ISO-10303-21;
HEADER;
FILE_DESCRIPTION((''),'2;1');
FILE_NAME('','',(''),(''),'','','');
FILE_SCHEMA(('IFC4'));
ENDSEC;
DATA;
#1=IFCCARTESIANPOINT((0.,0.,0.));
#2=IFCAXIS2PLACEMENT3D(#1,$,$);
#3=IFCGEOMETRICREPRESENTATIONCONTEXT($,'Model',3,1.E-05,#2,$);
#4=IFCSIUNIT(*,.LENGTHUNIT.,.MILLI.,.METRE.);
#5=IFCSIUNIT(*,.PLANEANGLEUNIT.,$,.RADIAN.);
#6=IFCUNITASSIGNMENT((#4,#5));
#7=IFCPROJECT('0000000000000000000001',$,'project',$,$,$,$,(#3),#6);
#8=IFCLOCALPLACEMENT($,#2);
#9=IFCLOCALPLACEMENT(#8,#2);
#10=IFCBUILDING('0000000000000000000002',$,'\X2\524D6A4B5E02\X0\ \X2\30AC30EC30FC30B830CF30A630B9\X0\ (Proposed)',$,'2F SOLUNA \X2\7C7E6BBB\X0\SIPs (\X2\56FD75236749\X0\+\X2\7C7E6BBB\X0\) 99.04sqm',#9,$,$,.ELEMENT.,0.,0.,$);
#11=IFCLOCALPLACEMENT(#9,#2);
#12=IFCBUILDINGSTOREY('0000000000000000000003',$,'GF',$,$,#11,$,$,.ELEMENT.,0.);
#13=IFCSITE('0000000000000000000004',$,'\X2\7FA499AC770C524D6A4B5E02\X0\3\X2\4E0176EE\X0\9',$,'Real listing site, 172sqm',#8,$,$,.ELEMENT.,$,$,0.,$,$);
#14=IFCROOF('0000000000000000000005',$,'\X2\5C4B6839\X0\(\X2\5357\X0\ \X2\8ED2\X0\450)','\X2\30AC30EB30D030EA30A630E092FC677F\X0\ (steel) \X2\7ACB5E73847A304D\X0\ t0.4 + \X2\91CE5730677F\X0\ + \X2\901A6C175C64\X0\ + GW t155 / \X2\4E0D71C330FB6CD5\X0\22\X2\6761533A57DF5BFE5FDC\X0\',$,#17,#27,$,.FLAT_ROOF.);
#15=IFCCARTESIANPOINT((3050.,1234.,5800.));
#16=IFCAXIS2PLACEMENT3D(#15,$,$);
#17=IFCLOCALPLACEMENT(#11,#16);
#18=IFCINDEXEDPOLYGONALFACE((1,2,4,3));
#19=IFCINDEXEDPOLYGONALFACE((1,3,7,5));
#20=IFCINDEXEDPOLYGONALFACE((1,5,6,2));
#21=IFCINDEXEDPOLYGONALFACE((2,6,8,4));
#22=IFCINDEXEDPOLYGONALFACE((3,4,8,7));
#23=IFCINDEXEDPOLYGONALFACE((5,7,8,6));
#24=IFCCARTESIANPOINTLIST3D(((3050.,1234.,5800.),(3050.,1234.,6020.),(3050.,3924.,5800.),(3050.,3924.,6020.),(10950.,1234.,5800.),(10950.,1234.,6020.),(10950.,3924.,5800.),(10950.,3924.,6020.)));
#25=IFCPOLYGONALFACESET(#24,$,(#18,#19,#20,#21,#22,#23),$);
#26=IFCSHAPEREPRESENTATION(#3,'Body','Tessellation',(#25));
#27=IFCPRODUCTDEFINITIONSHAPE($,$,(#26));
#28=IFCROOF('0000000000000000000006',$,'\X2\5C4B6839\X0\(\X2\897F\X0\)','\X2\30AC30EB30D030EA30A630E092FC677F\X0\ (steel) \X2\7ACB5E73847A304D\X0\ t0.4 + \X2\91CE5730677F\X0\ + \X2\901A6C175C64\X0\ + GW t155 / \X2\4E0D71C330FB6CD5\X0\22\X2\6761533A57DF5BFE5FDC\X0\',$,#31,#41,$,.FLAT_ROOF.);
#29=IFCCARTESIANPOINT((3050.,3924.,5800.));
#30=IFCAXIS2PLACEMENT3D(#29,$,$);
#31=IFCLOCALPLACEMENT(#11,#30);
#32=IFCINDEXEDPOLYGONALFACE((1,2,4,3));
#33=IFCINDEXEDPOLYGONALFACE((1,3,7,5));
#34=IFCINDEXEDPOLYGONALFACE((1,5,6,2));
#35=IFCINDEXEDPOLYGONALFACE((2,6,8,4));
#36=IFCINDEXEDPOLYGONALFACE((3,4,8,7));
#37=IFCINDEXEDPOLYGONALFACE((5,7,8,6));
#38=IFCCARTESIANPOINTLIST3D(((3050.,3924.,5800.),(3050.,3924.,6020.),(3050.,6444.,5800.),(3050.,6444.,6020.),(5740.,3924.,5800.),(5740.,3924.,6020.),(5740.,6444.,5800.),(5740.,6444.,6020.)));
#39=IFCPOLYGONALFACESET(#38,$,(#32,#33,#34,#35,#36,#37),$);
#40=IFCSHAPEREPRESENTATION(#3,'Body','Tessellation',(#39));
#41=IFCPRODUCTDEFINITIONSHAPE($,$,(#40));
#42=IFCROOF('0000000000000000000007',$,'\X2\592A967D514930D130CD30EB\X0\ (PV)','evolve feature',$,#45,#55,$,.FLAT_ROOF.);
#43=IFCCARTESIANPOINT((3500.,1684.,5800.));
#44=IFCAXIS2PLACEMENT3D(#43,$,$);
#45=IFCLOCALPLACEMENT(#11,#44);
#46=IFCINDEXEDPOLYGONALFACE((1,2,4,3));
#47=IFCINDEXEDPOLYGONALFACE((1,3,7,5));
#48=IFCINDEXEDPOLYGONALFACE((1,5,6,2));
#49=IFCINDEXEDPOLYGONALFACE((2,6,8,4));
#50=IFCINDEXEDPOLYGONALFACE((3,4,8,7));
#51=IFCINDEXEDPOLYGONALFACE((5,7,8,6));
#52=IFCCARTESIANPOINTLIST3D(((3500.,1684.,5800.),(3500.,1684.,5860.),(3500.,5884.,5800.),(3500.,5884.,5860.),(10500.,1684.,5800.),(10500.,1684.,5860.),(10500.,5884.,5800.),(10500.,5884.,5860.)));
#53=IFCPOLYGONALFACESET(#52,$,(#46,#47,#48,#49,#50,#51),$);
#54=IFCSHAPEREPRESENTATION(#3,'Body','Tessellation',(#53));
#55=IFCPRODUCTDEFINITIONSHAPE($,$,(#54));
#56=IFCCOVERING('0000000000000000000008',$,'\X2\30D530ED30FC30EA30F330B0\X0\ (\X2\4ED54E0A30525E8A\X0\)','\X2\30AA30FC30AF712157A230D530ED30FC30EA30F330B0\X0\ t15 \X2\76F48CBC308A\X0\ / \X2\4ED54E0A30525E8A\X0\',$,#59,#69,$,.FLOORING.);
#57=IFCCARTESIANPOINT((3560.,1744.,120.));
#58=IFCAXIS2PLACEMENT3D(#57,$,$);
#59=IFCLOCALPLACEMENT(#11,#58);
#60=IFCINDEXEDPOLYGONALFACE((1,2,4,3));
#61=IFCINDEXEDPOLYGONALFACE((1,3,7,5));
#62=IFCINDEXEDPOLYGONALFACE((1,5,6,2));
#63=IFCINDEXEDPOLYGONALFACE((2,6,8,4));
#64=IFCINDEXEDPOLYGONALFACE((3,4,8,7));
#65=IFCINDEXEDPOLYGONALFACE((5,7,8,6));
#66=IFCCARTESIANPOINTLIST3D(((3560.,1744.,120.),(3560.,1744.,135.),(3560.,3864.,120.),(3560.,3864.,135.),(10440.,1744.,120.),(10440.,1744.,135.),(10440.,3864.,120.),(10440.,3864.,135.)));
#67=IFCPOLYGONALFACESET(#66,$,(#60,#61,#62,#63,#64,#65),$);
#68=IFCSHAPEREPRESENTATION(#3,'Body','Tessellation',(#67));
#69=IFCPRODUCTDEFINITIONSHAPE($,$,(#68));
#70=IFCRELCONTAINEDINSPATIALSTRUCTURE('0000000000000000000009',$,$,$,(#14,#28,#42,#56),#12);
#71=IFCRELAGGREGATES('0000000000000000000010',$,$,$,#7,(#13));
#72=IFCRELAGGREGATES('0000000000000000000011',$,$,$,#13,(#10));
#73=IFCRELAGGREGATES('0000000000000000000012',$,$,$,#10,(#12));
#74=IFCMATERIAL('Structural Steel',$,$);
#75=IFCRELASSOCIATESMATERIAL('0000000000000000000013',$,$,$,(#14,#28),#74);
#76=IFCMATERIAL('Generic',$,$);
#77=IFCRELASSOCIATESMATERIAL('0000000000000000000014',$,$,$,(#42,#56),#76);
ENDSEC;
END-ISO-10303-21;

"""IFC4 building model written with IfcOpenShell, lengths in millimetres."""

from ifc_helpers import new_model, si_unit, frame, frame_2d, origin, place, context, project, spatial, rectangle, extrude, material, element, save


model = new_model("IFC4")

# Units and contexts
model_context = context("Model", 3, precision=1e-05, world=origin())
ifc_project = project(units=[si_unit("LENGTHUNIT", "METRE", prefix="MILLI"), si_unit("PLANEANGLEUNIT", "RADIAN")], contexts=[model_context])

# Site, building, storey
site_placement = place(None, origin())
site = spatial("IfcSite", under=ifc_project, at=site_placement, Name="群馬県前橋市3丁目9", ObjectType="Real listing site, 172sqm", CompositionType="ELEMENT", RefElevation=0.0)
building_placement = place(site_placement, origin())
building = spatial("IfcBuilding", under=site, at=building_placement, Name="前橋市 ガレージハウス (Proposed)", ObjectType="2F SOLUNA 籾殻SIPs (国産杉+籾殻) 99.04sqm", CompositionType="ELEMENT", ElevationOfRefHeight=0.0, ElevationOfTerrain=0.0)
storey_placement = place(building_placement, origin())
storey = spatial("IfcBuildingStorey", under=building, at=storey_placement, Name="GF", CompositionType="ELEMENT", Elevation=0.0)

# Shared definitions
ifc_material_1 = material(Name="Generic")

# Roofs
ifc_material_2 = material(Name="Structural Steel")
roof_1_placement = place(storey_placement, frame((3050.0, 1234.0, 5800.0)))
element("IfcRoof", 1, at=roof_1_placement, inside=storey, material=ifc_material_2, Name="屋根(南 軒450)", Description="ガルバリウム鋼板 (steel) 立平葺き t0.4 + 野地板 + 通気層 + GW t155 / 不燃・法22条区域対応", PredefinedType="FLAT_ROOF", context=model_context, shape_type="SweptSolid", body=[
    extrude(rectangle(XDim=7900.0, YDim=2690.0, at=frame_2d((3950.0, 1345.0))), frame((3050.0, 1234.0, 5800.0)), (0.0, 0.0, 1.0), 220.0),
])
roof_2_placement = place(storey_placement, frame((3050.0, 3924.0, 5800.0)))
element("IfcRoof", 2, at=roof_2_placement, inside=storey, material=ifc_material_2, Name="屋根(西)", Description="ガルバリウム鋼板 (steel) 立平葺き t0.4 + 野地板 + 通気層 + GW t155 / 不燃・法22条区域対応", PredefinedType="FLAT_ROOF", context=model_context, shape_type="SweptSolid", body=[
    extrude(rectangle(XDim=2690.0, YDim=2520.0, at=frame_2d((1345.0, 1260.0))), frame((3050.0, 3924.0, 5800.0)), (0.0, 0.0, 1.0), 220.0),
])
roof_3_placement = place(storey_placement, frame((3500.0, 1684.0, 5800.0)))
element("IfcRoof", 3, at=roof_3_placement, inside=storey, material=ifc_material_1, Name="太陽光パネル (PV)", Description="evolve feature", PredefinedType="FLAT_ROOF", context=model_context, shape_type="SweptSolid", body=[
    extrude(rectangle(XDim=7000.0, YDim=4200.0, at=frame_2d((3500.0, 2100.0))), frame((3500.0, 1684.0, 5800.0)), (0.0, 0.0, 1.0), 60.0),
])

# Covering
covering_placement = place(storey_placement, frame((3560.0, 1744.0, 120.0)))
element("IfcCovering", 4, at=covering_placement, inside=storey, material=ifc_material_1, Name="フローリング (仕上げ床)", Description="オーク無垢フローリング t15 直貼り / 仕上げ床", PredefinedType="FLOORING", context=model_context, shape_type="SweptSolid", body=[
    extrude(rectangle(XDim=6880.0, YDim=2120.0, at=frame_2d((3440.0, 1060.0))), frame((3560.0, 1744.0, 120.0)), (0.0, 0.0, 1.0), 15.0),
])

save(model, "model.ifc")
